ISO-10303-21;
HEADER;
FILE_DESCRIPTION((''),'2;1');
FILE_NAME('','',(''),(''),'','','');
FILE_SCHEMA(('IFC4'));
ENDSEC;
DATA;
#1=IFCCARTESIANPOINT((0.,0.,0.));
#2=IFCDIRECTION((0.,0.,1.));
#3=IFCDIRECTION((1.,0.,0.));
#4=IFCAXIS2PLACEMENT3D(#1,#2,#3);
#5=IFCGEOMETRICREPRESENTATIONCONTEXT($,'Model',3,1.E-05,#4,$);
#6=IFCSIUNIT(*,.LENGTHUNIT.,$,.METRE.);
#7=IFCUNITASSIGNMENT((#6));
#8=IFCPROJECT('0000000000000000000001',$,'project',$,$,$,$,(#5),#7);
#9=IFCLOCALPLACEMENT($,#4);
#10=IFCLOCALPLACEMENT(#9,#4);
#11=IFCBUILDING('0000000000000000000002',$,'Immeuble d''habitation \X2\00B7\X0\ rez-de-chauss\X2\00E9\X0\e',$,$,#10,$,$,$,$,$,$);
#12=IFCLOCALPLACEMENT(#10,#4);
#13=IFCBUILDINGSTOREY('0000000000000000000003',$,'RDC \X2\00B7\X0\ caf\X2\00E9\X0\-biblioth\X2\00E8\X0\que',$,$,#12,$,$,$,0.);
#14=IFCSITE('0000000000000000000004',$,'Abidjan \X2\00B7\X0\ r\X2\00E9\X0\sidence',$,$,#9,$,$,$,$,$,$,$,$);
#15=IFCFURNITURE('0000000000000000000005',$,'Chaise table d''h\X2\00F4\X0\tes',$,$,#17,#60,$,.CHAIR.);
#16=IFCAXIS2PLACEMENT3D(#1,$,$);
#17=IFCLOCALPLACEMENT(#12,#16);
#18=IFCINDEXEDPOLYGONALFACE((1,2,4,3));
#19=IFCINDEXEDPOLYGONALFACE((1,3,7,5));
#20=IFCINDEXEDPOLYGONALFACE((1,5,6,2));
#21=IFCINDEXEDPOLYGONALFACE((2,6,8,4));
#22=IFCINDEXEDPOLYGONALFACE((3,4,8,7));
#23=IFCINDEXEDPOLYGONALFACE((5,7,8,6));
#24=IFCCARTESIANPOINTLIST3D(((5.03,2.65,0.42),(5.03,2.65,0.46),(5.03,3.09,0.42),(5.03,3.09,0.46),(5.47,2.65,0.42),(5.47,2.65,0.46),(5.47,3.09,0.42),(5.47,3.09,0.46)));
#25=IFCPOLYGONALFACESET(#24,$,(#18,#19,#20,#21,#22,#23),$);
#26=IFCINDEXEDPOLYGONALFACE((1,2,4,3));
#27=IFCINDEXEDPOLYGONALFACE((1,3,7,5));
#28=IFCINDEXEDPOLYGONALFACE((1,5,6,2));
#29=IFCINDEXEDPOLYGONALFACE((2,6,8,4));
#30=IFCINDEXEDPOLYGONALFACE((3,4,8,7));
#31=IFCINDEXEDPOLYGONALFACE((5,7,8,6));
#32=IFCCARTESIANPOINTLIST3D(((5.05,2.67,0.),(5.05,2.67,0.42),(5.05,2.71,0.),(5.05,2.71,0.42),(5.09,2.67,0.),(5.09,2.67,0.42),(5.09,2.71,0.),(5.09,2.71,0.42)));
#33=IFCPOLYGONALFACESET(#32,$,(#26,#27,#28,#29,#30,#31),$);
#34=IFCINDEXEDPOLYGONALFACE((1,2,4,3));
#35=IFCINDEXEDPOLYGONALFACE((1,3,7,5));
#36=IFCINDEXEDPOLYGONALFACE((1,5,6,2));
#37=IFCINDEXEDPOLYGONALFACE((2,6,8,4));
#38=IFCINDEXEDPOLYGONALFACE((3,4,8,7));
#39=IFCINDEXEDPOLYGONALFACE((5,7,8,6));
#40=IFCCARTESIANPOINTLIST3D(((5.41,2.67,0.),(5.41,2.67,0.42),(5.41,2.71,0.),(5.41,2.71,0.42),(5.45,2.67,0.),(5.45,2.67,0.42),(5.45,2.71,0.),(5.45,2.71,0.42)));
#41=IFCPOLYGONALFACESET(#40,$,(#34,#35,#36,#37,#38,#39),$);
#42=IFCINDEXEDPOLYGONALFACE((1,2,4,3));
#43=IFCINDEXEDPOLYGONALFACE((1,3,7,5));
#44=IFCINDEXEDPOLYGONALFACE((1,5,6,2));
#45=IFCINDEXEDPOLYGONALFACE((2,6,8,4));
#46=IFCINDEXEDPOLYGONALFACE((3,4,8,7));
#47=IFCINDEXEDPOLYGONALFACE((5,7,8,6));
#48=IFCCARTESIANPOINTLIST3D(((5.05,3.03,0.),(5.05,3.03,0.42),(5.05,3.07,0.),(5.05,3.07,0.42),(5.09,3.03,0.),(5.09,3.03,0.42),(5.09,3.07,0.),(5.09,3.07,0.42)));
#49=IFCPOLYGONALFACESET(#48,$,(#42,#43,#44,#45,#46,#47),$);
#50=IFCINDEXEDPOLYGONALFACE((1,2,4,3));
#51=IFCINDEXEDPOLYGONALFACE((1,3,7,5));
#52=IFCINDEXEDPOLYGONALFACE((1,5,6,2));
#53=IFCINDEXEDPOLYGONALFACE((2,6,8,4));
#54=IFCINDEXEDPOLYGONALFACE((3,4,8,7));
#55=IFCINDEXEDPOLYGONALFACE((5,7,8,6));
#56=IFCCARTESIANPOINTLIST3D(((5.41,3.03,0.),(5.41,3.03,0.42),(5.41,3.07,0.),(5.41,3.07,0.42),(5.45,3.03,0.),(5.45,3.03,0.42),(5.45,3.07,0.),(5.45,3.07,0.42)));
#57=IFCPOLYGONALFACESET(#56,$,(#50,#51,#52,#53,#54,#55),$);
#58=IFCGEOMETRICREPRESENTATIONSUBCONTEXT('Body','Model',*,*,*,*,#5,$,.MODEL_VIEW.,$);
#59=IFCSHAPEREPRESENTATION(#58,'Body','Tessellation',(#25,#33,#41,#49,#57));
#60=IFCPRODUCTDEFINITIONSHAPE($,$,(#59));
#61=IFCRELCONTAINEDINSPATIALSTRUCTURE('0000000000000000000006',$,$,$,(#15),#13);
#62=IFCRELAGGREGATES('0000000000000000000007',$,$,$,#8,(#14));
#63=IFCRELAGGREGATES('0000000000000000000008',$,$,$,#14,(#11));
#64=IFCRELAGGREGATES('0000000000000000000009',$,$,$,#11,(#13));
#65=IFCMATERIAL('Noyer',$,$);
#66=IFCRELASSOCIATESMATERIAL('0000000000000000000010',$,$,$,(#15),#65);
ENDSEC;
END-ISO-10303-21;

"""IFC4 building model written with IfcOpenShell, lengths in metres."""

from ifc_helpers import new_model, si_unit, frame, frame_2d, origin, origin_with_axes, place, context, subcontext, project, spatial, rectangle, extrude, material, element, save


model = new_model("IFC4")

# Units and contexts
model_context = context("Model", 3, precision=1e-05, world=origin_with_axes())
body_context = subcontext(model_context, "Body", "Model", "MODEL_VIEW")
ifc_project = project(units=[si_unit("LENGTHUNIT", "METRE")], contexts=[model_context])

# Site, building, storey
site_placement = place(None, origin_with_axes())
site = spatial("IfcSite", under=ifc_project, at=site_placement, Name="Abidjan · résidence")
building_placement = place(site_placement, origin_with_axes())
building = spatial("IfcBuilding", under=site, at=building_placement, Name="Immeuble d'habitation · rez-de-chaussée")
storey_placement = place(building_placement, origin_with_axes())
storey = spatial("IfcBuildingStorey", under=building, at=storey_placement, Name="RDC · café-bibliothèque", Elevation=0.0)

# Furniture
ifc_material_1 = material(Name="Noyer")
furniture_1_placement = place(storey_placement, origin_with_axes())
element("IfcFurniture", 1, at=furniture_1_placement, inside=storey, material=ifc_material_1, Name="Chaise table d'hôtes", PredefinedType="CHAIR", context=body_context, shape_type="SweptSolid", body=[
    extrude(rectangle(XDim=0.44, YDim=0.44, at=frame_2d((5.25, 2.87))), frame((0.0, 0.0, 0.42)), (0.0, 0.0, 1.0), 0.04),
    extrude(rectangle(XDim=0.04, YDim=0.04, at=frame_2d((5.07, 2.69))), origin(), (0.0, 0.0, 1.0), 0.42),
    extrude(rectangle(XDim=0.04, YDim=0.04, at=frame_2d((5.43, 2.69))), origin(), (0.0, 0.0, 1.0), 0.42),
    extrude(rectangle(XDim=0.04, YDim=0.04, at=frame_2d((5.07, 3.05))), origin(), (0.0, 0.0, 1.0), 0.42),
    extrude(rectangle(XDim=0.04, YDim=0.04, at=frame_2d((5.43, 3.05))), origin(), (0.0, 0.0, 1.0), 0.42),
])

save(model, "model.ifc")
